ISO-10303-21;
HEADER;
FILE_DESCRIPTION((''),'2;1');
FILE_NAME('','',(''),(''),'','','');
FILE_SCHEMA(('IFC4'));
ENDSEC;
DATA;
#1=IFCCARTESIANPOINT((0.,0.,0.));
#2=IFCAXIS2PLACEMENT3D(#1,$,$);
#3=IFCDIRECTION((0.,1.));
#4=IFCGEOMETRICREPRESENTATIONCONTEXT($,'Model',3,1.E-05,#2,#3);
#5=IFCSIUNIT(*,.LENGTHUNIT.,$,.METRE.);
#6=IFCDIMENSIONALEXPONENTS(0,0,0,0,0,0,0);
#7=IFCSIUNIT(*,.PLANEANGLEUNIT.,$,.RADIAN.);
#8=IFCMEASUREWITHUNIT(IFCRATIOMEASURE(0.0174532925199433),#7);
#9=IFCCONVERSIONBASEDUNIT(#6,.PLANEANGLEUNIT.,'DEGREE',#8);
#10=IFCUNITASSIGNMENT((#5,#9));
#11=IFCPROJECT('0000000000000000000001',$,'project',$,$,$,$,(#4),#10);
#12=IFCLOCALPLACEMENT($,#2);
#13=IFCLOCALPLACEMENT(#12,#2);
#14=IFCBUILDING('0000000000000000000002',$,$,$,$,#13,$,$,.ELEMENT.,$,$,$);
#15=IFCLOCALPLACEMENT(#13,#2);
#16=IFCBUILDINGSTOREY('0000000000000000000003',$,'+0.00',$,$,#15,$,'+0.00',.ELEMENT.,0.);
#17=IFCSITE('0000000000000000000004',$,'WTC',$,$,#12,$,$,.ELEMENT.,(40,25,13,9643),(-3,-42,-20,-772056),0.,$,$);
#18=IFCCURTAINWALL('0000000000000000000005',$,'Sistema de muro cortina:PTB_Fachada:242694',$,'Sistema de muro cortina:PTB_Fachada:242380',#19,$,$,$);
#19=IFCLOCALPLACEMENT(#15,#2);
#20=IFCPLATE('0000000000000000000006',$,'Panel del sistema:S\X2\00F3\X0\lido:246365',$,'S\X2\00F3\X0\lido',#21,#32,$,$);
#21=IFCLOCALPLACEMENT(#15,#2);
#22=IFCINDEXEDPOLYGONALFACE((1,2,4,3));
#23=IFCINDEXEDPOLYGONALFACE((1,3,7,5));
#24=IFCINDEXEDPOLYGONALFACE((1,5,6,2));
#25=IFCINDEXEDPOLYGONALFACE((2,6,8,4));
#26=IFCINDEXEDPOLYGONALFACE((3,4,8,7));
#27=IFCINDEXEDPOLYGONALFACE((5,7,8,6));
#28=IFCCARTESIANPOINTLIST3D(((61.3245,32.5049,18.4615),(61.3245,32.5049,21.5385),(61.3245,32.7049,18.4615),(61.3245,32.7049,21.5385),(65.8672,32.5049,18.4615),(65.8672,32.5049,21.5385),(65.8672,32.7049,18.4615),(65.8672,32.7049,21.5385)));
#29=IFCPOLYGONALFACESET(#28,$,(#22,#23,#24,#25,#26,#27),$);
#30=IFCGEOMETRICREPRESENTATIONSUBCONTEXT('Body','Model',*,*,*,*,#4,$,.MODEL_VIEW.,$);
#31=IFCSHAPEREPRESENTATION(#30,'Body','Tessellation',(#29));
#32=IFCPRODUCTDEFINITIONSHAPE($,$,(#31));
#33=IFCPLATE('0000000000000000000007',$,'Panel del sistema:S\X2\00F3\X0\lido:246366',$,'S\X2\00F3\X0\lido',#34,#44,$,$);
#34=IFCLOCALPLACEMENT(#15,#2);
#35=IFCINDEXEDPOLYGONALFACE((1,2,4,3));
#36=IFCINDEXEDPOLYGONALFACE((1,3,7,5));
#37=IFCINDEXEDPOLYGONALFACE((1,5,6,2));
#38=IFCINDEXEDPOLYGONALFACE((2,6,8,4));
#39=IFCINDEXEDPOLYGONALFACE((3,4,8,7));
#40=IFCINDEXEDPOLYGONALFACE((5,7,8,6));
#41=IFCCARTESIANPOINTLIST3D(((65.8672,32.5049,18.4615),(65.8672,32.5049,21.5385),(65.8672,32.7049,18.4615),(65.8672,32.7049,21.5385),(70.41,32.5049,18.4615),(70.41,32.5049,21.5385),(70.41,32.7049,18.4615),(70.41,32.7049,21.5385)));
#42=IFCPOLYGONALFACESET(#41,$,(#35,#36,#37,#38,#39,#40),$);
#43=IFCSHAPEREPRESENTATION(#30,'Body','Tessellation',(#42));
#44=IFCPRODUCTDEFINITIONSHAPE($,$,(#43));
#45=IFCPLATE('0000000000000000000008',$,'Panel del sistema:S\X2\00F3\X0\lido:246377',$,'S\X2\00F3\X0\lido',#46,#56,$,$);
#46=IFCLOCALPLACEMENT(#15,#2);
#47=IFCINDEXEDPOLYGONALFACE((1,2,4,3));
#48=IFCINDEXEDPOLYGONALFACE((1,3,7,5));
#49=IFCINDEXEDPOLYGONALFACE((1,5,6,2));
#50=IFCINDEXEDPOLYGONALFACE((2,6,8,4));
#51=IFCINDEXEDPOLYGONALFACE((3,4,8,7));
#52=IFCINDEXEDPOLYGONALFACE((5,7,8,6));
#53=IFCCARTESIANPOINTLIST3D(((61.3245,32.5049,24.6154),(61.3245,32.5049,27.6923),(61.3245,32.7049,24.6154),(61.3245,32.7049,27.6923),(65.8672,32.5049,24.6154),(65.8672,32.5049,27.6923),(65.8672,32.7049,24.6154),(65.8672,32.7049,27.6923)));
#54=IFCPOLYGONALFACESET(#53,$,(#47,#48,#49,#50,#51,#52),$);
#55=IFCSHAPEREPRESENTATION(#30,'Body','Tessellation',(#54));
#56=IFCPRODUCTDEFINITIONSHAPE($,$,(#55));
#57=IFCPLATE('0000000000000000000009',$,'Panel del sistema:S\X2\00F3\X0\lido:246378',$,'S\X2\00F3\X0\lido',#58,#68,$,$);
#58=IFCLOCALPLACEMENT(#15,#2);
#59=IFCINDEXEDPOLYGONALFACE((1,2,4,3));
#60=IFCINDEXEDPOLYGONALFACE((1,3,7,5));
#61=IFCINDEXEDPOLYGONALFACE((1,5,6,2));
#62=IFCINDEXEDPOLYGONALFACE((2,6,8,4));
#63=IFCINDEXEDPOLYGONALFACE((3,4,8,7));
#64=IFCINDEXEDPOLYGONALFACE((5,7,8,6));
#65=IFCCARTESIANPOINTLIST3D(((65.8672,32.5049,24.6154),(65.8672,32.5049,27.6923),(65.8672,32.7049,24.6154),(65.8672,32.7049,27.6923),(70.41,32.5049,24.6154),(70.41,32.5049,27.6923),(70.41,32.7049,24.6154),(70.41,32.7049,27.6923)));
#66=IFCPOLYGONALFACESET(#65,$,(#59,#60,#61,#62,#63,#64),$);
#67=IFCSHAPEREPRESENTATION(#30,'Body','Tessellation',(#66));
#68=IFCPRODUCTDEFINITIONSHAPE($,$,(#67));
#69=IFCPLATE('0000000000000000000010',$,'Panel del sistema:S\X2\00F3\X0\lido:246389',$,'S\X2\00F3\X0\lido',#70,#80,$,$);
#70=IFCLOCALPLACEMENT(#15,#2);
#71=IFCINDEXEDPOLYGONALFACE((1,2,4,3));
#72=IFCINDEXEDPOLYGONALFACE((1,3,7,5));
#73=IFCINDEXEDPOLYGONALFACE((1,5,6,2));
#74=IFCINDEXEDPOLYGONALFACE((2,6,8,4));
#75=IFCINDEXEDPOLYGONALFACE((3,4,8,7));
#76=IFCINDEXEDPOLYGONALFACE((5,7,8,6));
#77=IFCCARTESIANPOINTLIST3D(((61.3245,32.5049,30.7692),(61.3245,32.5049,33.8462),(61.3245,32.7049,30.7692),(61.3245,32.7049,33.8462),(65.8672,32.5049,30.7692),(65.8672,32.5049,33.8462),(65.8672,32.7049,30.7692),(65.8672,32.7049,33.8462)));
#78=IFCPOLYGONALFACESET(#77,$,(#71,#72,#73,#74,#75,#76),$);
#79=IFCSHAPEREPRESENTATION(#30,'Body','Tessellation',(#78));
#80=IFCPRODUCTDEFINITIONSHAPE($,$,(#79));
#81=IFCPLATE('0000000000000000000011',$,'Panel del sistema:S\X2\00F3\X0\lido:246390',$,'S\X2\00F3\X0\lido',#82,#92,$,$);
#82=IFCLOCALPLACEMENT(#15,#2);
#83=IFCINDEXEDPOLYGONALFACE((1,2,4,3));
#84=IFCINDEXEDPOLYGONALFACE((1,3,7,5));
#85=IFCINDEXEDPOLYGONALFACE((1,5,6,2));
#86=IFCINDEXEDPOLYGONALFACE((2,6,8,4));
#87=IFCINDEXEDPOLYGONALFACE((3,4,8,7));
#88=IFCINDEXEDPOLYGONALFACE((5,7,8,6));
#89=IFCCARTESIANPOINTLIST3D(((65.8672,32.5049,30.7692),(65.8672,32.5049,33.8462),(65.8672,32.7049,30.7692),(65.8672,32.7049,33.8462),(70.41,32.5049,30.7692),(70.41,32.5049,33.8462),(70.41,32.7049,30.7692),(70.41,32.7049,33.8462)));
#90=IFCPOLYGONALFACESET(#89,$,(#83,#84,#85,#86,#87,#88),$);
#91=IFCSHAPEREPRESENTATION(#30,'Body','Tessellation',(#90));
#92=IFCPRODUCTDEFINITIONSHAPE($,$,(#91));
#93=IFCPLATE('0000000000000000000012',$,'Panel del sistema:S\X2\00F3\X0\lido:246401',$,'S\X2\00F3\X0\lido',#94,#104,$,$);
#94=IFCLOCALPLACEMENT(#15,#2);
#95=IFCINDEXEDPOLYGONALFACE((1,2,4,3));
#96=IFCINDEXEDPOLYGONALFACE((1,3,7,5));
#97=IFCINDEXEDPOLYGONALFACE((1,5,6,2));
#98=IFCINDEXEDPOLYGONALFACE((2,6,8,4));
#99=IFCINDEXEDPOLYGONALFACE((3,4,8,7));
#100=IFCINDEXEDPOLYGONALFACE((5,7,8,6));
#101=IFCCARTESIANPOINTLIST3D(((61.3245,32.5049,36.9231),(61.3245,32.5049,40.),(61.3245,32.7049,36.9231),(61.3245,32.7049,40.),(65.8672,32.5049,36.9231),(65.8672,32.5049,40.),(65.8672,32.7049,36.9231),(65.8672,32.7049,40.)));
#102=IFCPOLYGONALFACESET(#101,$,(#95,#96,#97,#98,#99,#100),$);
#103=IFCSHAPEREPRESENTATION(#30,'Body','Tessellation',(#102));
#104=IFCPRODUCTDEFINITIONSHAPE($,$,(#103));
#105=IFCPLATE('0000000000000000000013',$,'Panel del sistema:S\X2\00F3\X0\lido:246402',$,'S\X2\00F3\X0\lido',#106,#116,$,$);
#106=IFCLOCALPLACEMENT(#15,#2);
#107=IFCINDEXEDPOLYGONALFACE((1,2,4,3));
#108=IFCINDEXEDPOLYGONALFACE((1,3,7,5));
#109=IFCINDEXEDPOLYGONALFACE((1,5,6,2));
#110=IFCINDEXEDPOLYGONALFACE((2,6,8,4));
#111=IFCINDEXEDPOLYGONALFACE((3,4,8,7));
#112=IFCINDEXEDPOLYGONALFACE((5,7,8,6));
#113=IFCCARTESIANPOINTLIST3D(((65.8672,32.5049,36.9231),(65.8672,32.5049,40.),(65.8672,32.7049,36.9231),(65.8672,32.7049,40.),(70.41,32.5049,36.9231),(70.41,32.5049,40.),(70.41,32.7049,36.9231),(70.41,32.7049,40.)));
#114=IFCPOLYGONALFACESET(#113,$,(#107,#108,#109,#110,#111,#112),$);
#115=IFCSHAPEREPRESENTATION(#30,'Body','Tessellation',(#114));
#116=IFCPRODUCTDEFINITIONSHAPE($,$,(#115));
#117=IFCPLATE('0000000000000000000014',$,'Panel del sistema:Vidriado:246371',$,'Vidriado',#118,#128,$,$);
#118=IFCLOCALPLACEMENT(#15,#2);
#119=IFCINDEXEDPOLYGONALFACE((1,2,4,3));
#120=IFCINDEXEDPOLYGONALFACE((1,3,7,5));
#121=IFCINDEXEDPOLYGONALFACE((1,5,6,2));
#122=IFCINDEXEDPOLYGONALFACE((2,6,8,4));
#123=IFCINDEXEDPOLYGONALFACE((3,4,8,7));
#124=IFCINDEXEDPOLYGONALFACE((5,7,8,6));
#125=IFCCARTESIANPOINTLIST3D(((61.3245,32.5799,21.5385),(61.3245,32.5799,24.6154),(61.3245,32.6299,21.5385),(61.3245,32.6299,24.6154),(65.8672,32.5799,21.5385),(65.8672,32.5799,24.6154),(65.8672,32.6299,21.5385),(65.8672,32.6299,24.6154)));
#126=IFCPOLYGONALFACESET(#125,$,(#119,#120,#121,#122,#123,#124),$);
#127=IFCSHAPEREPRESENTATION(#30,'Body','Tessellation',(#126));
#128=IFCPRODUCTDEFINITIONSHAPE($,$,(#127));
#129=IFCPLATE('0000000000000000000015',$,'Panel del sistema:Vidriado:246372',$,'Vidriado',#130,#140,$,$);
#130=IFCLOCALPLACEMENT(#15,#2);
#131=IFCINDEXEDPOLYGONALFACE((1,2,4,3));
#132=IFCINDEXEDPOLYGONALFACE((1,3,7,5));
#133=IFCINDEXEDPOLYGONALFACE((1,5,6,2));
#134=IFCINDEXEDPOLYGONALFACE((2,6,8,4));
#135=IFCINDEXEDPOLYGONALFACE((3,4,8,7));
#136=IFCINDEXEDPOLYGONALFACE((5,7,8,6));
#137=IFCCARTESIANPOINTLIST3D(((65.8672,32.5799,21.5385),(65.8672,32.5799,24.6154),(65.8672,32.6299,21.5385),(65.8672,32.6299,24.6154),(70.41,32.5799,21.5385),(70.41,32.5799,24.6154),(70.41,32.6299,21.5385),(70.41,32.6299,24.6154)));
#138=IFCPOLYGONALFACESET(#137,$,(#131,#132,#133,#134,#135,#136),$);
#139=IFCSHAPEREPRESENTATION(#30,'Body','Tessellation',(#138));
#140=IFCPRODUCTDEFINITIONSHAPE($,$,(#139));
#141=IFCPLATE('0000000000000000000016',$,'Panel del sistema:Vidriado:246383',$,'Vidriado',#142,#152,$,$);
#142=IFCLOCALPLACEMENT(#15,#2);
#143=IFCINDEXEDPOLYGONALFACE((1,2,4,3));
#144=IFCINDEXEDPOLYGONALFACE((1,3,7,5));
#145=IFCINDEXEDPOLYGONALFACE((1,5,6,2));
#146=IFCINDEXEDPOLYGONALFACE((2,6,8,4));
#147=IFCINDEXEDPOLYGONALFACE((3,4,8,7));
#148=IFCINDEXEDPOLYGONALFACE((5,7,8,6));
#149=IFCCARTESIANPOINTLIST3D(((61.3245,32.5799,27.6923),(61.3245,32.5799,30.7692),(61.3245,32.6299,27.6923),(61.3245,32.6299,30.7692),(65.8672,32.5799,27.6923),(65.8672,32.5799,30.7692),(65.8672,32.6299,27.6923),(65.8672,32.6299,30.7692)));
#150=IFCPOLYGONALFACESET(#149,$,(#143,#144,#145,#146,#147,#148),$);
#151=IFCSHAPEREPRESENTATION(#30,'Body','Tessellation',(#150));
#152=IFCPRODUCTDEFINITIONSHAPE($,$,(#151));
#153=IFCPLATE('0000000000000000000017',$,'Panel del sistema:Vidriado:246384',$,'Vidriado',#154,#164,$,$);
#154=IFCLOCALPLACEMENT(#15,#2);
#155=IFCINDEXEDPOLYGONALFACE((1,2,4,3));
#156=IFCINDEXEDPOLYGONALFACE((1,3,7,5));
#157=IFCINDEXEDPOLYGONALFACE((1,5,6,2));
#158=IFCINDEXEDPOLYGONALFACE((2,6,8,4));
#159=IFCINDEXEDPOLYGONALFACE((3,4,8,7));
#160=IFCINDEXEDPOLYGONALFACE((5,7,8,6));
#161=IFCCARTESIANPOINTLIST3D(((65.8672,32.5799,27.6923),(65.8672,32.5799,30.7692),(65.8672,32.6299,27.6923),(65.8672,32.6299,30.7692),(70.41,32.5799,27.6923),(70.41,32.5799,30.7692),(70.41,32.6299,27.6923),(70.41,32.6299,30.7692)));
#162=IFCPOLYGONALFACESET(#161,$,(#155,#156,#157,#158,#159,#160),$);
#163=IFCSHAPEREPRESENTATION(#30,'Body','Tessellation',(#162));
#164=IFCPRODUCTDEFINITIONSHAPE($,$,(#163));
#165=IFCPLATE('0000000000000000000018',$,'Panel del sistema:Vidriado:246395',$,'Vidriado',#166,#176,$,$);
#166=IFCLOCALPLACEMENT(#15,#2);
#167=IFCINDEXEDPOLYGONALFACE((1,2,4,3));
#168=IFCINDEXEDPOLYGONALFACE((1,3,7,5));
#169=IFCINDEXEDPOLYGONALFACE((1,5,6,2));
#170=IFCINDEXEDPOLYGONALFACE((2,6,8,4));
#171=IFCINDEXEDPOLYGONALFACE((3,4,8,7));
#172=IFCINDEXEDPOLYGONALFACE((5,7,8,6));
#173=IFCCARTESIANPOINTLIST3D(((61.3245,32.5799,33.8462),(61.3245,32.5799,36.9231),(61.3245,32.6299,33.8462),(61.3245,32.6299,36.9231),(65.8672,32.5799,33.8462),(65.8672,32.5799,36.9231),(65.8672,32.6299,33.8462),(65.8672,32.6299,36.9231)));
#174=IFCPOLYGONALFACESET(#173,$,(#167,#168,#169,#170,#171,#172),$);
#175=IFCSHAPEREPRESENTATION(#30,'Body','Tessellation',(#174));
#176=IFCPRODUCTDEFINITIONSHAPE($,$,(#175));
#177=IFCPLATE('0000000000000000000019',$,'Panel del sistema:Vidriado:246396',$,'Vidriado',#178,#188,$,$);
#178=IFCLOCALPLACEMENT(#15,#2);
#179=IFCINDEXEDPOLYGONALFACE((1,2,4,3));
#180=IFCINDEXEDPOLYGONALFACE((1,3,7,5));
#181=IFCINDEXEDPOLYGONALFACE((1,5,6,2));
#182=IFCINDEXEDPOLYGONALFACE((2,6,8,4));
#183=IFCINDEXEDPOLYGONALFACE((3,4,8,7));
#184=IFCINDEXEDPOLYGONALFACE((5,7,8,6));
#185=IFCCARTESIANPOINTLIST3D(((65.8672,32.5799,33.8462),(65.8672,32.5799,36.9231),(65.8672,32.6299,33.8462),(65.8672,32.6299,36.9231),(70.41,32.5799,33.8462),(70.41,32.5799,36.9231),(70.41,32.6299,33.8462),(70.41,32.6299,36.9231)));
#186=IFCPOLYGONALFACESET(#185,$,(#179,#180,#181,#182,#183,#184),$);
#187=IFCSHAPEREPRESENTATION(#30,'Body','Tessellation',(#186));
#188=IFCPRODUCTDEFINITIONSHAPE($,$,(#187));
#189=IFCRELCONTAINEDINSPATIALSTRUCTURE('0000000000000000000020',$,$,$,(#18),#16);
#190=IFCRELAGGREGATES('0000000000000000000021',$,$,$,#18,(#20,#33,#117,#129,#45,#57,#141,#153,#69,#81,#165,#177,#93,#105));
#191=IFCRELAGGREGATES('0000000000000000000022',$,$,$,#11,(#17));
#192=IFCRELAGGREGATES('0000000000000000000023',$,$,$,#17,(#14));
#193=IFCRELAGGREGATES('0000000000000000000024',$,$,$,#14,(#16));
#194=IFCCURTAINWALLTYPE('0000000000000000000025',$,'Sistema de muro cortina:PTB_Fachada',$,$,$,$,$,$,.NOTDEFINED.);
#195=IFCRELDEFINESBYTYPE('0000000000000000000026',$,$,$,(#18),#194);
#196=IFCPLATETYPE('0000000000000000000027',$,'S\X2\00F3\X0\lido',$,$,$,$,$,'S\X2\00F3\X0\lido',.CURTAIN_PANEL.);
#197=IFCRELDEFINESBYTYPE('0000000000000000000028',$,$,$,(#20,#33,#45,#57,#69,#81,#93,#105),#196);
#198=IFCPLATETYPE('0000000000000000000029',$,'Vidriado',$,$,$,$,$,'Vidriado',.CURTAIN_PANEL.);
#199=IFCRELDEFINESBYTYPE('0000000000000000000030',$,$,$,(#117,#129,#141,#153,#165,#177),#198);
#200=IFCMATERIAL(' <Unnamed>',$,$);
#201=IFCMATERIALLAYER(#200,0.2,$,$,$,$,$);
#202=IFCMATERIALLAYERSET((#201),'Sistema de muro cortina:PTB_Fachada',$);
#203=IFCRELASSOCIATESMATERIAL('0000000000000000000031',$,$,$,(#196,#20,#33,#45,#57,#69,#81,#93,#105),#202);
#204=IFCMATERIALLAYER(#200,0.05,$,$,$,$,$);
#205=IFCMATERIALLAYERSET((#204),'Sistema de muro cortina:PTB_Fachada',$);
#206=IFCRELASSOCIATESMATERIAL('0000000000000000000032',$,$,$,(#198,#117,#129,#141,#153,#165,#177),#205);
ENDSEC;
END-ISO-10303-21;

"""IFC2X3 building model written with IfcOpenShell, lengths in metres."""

from ifc_helpers import new_model, entity, si_unit, converted_unit, direction, frame, origin, origin_2d_with_axis, place, context, subcontext, project, spatial, rectangle, extrude, source, transform, mapped, material, layer, layer_set, layer_usage, type_object, type_shapes, element, aggregate, save


model = new_model("IFC2X3")

# Units and contexts
model_context = context("Model", 3, precision=1e-05, world=origin(), true_north=direction((0.0, 1.0)))
body_context = subcontext(model_context, "Body", "Model", "MODEL_VIEW")
ifc_project = project(units=[si_unit("LENGTHUNIT", "METRE"), converted_unit("PLANEANGLEUNIT", "DEGREE", entity("IfcRatioMeasure", 0.0174532925199433), si_unit("PLANEANGLEUNIT", "RADIAN"), dimensions=[0, 0, 0, 0, 0, 0, 0])], contexts=[model_context])

# Site, building, storey
site_placement = place(None, origin())
site = spatial("IfcSite", under=ifc_project, at=site_placement, Name="WTC", CompositionType="ELEMENT", RefLatitude=(40, 25, 13, 9643), RefLongitude=(-3, -42, -20, -772056), RefElevation=0.0)
building_placement = place(site_placement, origin())
building = spatial("IfcBuilding", under=site, at=building_placement, CompositionType="ELEMENT")
storey_placement = place(building_placement, origin())
storey = spatial("IfcBuildingStorey", under=building, at=storey_placement, Name="+0.00", LongName="+0.00", CompositionType="ELEMENT", Elevation=0.0)

# Curtain wall, plates
curtain_wall_type = type_object("IfcCurtainWallType", Name="Sistema de muro cortina:PTB_Fachada", PredefinedType="NOTDEFINED")
curtain_wall_1_placement = place(storey_placement, origin())
curtain_wall_1 = element("IfcCurtainWall", 1, at=curtain_wall_1_placement, inside=storey, type_object=curtain_wall_type, Name="Sistema de muro cortina:PTB_Fachada:242694", ObjectType="Sistema de muro cortina:PTB_Fachada:242380")
ifc_material_1 = material(Name=" <Unnamed>")
ifc_layer_1 = layer(ifc_material_1, 0.2)
ifc_layer_set_1 = layer_set([ifc_layer_1], Name="Sistema de muro cortina:PTB_Fachada")
ifc_layer_usage_1 = layer_usage(ifc_layer_set_1, "AXIS3", "POSITIVE", 0.0)
plate_type_1 = type_object("IfcPlateType", Name="Sólido", ElementType="Sólido", PredefinedType="CURTAIN_PANEL", material=ifc_layer_set_1)
shared_shape_1 = source(origin(), body_context, "Body", "SweptSolid", [
    extrude(rectangle(XDim=0.2, YDim=4.5427, at=origin_2d_with_axis()), frame((0.0, 0.0, 0.0), z_axis=(0.0, 0.0, 1.0), x_axis=(0.0, 1.0, 0.0)), (0.0, 0.0, 1.0), 3.0769),
])
type_shapes(plate_type_1, [shared_shape_1])
plate_1_placement = place(curtain_wall_1_placement, frame((63.5959, 32.6049, 18.4615)))
plate_1 = element("IfcPlate", 2, at=plate_1_placement, type_object=plate_type_1, material=ifc_layer_usage_1, Name="Panel del sistema:Sólido:246365", ObjectType="Sólido", context=body_context, shape_type="MappedRepresentation", body=[
    mapped(shared_shape_1, transform((0.0, 0.0, 0.0), scale=1.0)),
])
ifc_layer_usage_2 = layer_usage(ifc_layer_set_1, "AXIS3", "POSITIVE", 0.0)
plate_2_placement = place(curtain_wall_1_placement, frame((68.1386, 32.6049, 18.4615)))
plate_2 = element("IfcPlate", 3, at=plate_2_placement, type_object=plate_type_1, material=ifc_layer_usage_2, Name="Panel del sistema:Sólido:246366", ObjectType="Sólido", context=body_context, shape_type="MappedRepresentation", body=[
    mapped(shared_shape_1, transform((0.0, 0.0, 0.0), scale=1.0)),
])
ifc_layer_usage_3 = layer_usage(ifc_layer_set_1, "AXIS3", "POSITIVE", 0.0)
plate_3_placement = place(curtain_wall_1_placement, frame((63.5959, 32.6049, 24.6154)))
plate_3 = element("IfcPlate", 4, at=plate_3_placement, type_object=plate_type_1, material=ifc_layer_usage_3, Name="Panel del sistema:Sólido:246377", ObjectType="Sólido", context=body_context, shape_type="MappedRepresentation", body=[
    mapped(shared_shape_1, transform((0.0, 0.0, 0.0), scale=1.0)),
])
ifc_layer_usage_4 = layer_usage(ifc_layer_set_1, "AXIS3", "POSITIVE", 0.0)
plate_4_placement = place(curtain_wall_1_placement, frame((68.1386, 32.6049, 24.6154)))
plate_4 = element("IfcPlate", 5, at=plate_4_placement, type_object=plate_type_1, material=ifc_layer_usage_4, Name="Panel del sistema:Sólido:246378", ObjectType="Sólido", context=body_context, shape_type="MappedRepresentation", body=[
    mapped(shared_shape_1, transform((0.0, 0.0, 0.0), scale=1.0)),
])
ifc_layer_usage_5 = layer_usage(ifc_layer_set_1, "AXIS3", "POSITIVE", 0.0)
plate_5_placement = place(curtain_wall_1_placement, frame((63.5959, 32.6049, 30.7692)))
plate_5 = element("IfcPlate", 6, at=plate_5_placement, type_object=plate_type_1, material=ifc_layer_usage_5, Name="Panel del sistema:Sólido:246389", ObjectType="Sólido", context=body_context, shape_type="MappedRepresentation", body=[
    mapped(shared_shape_1, transform((0.0, 0.0, 0.0), scale=1.0)),
])
ifc_layer_usage_6 = layer_usage(ifc_layer_set_1, "AXIS3", "POSITIVE", 0.0)
plate_6_placement = place(curtain_wall_1_placement, frame((68.1386, 32.6049, 30.7692)))
plate_6 = element("IfcPlate", 7, at=plate_6_placement, type_object=plate_type_1, material=ifc_layer_usage_6, Name="Panel del sistema:Sólido:246390", ObjectType="Sólido", context=body_context, shape_type="MappedRepresentation", body=[
    mapped(shared_shape_1, transform((0.0, 0.0, 0.0), scale=1.0)),
])
ifc_layer_usage_7 = layer_usage(ifc_layer_set_1, "AXIS3", "POSITIVE", 0.0)
plate_7_placement = place(curtain_wall_1_placement, frame((63.5959, 32.6049, 36.9231)))
plate_7 = element("IfcPlate", 8, at=plate_7_placement, type_object=plate_type_1, material=ifc_layer_usage_7, Name="Panel del sistema:Sólido:246401", ObjectType="Sólido", context=body_context, shape_type="MappedRepresentation", body=[
    mapped(shared_shape_1, transform((0.0, 0.0, 0.0), scale=1.0)),
])
ifc_layer_usage_8 = layer_usage(ifc_layer_set_1, "AXIS3", "POSITIVE", 0.0)
plate_8_placement = place(curtain_wall_1_placement, frame((68.1386, 32.6049, 36.9231)))
plate_8 = element("IfcPlate", 9, at=plate_8_placement, type_object=plate_type_1, material=ifc_layer_usage_8, Name="Panel del sistema:Sólido:246402", ObjectType="Sólido", context=body_context, shape_type="MappedRepresentation", body=[
    mapped(shared_shape_1, transform((0.0, 0.0, 0.0), scale=1.0)),
])
ifc_layer_2 = layer(ifc_material_1, 0.05)
ifc_layer_set_2 = layer_set([ifc_layer_2], Name="Sistema de muro cortina:PTB_Fachada")
ifc_layer_usage_9 = layer_usage(ifc_layer_set_2, "AXIS3", "POSITIVE", 0.0)
plate_type_2 = type_object("IfcPlateType", Name="Vidriado", ElementType="Vidriado", PredefinedType="CURTAIN_PANEL", material=ifc_layer_set_2)
shared_shape_2 = source(origin(), body_context, "Body", "SweptSolid", [
    extrude(rectangle(XDim=0.05, YDim=4.5427, at=origin_2d_with_axis()), frame((0.0, 0.0, 0.0), z_axis=(0.0, 0.0, 1.0), x_axis=(0.0, 1.0, 0.0)), (0.0, 0.0, 1.0), 3.0769),
])
type_shapes(plate_type_2, [shared_shape_2])
plate_9_placement = place(curtain_wall_1_placement, frame((63.5959, 32.6049, 21.5385)))
plate_9 = element("IfcPlate", 10, at=plate_9_placement, type_object=plate_type_2, material=ifc_layer_usage_9, Name="Panel del sistema:Vidriado:246371", ObjectType="Vidriado", context=body_context, shape_type="MappedRepresentation", body=[
    mapped(shared_shape_2, transform((0.0, 0.0, 0.0), scale=1.0)),
])
ifc_layer_usage_10 = layer_usage(ifc_layer_set_2, "AXIS3", "POSITIVE", 0.0)
plate_10_placement = place(curtain_wall_1_placement, frame((68.1386, 32.6049, 21.5385)))
plate_10 = element("IfcPlate", 11, at=plate_10_placement, type_object=plate_type_2, material=ifc_layer_usage_10, Name="Panel del sistema:Vidriado:246372", ObjectType="Vidriado", context=body_context, shape_type="MappedRepresentation", body=[
    mapped(shared_shape_2, transform((0.0, 0.0, 0.0), scale=1.0)),
])
ifc_layer_usage_11 = layer_usage(ifc_layer_set_2, "AXIS3", "POSITIVE", 0.0)
plate_11_placement = place(curtain_wall_1_placement, frame((63.5959, 32.6049, 27.6923)))
plate_11 = element("IfcPlate", 12, at=plate_11_placement, type_object=plate_type_2, material=ifc_layer_usage_11, Name="Panel del sistema:Vidriado:246383", ObjectType="Vidriado", context=body_context, shape_type="MappedRepresentation", body=[
    mapped(shared_shape_2, transform((0.0, 0.0, 0.0), scale=1.0)),
])
ifc_layer_usage_12 = layer_usage(ifc_layer_set_2, "AXIS3", "POSITIVE", 0.0)
plate_12_placement = place(curtain_wall_1_placement, frame((68.1386, 32.6049, 27.6923)))
plate_12 = element("IfcPlate", 13, at=plate_12_placement, type_object=plate_type_2, material=ifc_layer_usage_12, Name="Panel del sistema:Vidriado:246384", ObjectType="Vidriado", context=body_context, shape_type="MappedRepresentation", body=[
    mapped(shared_shape_2, transform((0.0, 0.0, 0.0), scale=1.0)),
])
ifc_layer_usage_13 = layer_usage(ifc_layer_set_2, "AXIS3", "POSITIVE", 0.0)
plate_13_placement = place(curtain_wall_1_placement, frame((63.5959, 32.6049, 33.8462)))
plate_13 = element("IfcPlate", 14, at=plate_13_placement, type_object=plate_type_2, material=ifc_layer_usage_13, Name="Panel del sistema:Vidriado:246395", ObjectType="Vidriado", context=body_context, shape_type="MappedRepresentation", body=[
    mapped(shared_shape_2, transform((0.0, 0.0, 0.0), scale=1.0)),
])
ifc_layer_usage_14 = layer_usage(ifc_layer_set_2, "AXIS3", "POSITIVE", 0.0)
plate_14_placement = place(curtain_wall_1_placement, frame((68.1386, 32.6049, 33.8462)))
plate_14 = element("IfcPlate", 15, at=plate_14_placement, type_object=plate_type_2, material=ifc_layer_usage_14, Name="Panel del sistema:Vidriado:246396", ObjectType="Vidriado", context=body_context, shape_type="MappedRepresentation", body=[
    mapped(shared_shape_2, transform((0.0, 0.0, 0.0), scale=1.0)),
])
aggregate(curtain_wall_1, [plate_1, plate_2, plate_9, plate_10, plate_3, plate_4, plate_11, plate_12, plate_5, plate_6, plate_13, plate_14, plate_7, plate_8])

save(model, "model.ifc")
